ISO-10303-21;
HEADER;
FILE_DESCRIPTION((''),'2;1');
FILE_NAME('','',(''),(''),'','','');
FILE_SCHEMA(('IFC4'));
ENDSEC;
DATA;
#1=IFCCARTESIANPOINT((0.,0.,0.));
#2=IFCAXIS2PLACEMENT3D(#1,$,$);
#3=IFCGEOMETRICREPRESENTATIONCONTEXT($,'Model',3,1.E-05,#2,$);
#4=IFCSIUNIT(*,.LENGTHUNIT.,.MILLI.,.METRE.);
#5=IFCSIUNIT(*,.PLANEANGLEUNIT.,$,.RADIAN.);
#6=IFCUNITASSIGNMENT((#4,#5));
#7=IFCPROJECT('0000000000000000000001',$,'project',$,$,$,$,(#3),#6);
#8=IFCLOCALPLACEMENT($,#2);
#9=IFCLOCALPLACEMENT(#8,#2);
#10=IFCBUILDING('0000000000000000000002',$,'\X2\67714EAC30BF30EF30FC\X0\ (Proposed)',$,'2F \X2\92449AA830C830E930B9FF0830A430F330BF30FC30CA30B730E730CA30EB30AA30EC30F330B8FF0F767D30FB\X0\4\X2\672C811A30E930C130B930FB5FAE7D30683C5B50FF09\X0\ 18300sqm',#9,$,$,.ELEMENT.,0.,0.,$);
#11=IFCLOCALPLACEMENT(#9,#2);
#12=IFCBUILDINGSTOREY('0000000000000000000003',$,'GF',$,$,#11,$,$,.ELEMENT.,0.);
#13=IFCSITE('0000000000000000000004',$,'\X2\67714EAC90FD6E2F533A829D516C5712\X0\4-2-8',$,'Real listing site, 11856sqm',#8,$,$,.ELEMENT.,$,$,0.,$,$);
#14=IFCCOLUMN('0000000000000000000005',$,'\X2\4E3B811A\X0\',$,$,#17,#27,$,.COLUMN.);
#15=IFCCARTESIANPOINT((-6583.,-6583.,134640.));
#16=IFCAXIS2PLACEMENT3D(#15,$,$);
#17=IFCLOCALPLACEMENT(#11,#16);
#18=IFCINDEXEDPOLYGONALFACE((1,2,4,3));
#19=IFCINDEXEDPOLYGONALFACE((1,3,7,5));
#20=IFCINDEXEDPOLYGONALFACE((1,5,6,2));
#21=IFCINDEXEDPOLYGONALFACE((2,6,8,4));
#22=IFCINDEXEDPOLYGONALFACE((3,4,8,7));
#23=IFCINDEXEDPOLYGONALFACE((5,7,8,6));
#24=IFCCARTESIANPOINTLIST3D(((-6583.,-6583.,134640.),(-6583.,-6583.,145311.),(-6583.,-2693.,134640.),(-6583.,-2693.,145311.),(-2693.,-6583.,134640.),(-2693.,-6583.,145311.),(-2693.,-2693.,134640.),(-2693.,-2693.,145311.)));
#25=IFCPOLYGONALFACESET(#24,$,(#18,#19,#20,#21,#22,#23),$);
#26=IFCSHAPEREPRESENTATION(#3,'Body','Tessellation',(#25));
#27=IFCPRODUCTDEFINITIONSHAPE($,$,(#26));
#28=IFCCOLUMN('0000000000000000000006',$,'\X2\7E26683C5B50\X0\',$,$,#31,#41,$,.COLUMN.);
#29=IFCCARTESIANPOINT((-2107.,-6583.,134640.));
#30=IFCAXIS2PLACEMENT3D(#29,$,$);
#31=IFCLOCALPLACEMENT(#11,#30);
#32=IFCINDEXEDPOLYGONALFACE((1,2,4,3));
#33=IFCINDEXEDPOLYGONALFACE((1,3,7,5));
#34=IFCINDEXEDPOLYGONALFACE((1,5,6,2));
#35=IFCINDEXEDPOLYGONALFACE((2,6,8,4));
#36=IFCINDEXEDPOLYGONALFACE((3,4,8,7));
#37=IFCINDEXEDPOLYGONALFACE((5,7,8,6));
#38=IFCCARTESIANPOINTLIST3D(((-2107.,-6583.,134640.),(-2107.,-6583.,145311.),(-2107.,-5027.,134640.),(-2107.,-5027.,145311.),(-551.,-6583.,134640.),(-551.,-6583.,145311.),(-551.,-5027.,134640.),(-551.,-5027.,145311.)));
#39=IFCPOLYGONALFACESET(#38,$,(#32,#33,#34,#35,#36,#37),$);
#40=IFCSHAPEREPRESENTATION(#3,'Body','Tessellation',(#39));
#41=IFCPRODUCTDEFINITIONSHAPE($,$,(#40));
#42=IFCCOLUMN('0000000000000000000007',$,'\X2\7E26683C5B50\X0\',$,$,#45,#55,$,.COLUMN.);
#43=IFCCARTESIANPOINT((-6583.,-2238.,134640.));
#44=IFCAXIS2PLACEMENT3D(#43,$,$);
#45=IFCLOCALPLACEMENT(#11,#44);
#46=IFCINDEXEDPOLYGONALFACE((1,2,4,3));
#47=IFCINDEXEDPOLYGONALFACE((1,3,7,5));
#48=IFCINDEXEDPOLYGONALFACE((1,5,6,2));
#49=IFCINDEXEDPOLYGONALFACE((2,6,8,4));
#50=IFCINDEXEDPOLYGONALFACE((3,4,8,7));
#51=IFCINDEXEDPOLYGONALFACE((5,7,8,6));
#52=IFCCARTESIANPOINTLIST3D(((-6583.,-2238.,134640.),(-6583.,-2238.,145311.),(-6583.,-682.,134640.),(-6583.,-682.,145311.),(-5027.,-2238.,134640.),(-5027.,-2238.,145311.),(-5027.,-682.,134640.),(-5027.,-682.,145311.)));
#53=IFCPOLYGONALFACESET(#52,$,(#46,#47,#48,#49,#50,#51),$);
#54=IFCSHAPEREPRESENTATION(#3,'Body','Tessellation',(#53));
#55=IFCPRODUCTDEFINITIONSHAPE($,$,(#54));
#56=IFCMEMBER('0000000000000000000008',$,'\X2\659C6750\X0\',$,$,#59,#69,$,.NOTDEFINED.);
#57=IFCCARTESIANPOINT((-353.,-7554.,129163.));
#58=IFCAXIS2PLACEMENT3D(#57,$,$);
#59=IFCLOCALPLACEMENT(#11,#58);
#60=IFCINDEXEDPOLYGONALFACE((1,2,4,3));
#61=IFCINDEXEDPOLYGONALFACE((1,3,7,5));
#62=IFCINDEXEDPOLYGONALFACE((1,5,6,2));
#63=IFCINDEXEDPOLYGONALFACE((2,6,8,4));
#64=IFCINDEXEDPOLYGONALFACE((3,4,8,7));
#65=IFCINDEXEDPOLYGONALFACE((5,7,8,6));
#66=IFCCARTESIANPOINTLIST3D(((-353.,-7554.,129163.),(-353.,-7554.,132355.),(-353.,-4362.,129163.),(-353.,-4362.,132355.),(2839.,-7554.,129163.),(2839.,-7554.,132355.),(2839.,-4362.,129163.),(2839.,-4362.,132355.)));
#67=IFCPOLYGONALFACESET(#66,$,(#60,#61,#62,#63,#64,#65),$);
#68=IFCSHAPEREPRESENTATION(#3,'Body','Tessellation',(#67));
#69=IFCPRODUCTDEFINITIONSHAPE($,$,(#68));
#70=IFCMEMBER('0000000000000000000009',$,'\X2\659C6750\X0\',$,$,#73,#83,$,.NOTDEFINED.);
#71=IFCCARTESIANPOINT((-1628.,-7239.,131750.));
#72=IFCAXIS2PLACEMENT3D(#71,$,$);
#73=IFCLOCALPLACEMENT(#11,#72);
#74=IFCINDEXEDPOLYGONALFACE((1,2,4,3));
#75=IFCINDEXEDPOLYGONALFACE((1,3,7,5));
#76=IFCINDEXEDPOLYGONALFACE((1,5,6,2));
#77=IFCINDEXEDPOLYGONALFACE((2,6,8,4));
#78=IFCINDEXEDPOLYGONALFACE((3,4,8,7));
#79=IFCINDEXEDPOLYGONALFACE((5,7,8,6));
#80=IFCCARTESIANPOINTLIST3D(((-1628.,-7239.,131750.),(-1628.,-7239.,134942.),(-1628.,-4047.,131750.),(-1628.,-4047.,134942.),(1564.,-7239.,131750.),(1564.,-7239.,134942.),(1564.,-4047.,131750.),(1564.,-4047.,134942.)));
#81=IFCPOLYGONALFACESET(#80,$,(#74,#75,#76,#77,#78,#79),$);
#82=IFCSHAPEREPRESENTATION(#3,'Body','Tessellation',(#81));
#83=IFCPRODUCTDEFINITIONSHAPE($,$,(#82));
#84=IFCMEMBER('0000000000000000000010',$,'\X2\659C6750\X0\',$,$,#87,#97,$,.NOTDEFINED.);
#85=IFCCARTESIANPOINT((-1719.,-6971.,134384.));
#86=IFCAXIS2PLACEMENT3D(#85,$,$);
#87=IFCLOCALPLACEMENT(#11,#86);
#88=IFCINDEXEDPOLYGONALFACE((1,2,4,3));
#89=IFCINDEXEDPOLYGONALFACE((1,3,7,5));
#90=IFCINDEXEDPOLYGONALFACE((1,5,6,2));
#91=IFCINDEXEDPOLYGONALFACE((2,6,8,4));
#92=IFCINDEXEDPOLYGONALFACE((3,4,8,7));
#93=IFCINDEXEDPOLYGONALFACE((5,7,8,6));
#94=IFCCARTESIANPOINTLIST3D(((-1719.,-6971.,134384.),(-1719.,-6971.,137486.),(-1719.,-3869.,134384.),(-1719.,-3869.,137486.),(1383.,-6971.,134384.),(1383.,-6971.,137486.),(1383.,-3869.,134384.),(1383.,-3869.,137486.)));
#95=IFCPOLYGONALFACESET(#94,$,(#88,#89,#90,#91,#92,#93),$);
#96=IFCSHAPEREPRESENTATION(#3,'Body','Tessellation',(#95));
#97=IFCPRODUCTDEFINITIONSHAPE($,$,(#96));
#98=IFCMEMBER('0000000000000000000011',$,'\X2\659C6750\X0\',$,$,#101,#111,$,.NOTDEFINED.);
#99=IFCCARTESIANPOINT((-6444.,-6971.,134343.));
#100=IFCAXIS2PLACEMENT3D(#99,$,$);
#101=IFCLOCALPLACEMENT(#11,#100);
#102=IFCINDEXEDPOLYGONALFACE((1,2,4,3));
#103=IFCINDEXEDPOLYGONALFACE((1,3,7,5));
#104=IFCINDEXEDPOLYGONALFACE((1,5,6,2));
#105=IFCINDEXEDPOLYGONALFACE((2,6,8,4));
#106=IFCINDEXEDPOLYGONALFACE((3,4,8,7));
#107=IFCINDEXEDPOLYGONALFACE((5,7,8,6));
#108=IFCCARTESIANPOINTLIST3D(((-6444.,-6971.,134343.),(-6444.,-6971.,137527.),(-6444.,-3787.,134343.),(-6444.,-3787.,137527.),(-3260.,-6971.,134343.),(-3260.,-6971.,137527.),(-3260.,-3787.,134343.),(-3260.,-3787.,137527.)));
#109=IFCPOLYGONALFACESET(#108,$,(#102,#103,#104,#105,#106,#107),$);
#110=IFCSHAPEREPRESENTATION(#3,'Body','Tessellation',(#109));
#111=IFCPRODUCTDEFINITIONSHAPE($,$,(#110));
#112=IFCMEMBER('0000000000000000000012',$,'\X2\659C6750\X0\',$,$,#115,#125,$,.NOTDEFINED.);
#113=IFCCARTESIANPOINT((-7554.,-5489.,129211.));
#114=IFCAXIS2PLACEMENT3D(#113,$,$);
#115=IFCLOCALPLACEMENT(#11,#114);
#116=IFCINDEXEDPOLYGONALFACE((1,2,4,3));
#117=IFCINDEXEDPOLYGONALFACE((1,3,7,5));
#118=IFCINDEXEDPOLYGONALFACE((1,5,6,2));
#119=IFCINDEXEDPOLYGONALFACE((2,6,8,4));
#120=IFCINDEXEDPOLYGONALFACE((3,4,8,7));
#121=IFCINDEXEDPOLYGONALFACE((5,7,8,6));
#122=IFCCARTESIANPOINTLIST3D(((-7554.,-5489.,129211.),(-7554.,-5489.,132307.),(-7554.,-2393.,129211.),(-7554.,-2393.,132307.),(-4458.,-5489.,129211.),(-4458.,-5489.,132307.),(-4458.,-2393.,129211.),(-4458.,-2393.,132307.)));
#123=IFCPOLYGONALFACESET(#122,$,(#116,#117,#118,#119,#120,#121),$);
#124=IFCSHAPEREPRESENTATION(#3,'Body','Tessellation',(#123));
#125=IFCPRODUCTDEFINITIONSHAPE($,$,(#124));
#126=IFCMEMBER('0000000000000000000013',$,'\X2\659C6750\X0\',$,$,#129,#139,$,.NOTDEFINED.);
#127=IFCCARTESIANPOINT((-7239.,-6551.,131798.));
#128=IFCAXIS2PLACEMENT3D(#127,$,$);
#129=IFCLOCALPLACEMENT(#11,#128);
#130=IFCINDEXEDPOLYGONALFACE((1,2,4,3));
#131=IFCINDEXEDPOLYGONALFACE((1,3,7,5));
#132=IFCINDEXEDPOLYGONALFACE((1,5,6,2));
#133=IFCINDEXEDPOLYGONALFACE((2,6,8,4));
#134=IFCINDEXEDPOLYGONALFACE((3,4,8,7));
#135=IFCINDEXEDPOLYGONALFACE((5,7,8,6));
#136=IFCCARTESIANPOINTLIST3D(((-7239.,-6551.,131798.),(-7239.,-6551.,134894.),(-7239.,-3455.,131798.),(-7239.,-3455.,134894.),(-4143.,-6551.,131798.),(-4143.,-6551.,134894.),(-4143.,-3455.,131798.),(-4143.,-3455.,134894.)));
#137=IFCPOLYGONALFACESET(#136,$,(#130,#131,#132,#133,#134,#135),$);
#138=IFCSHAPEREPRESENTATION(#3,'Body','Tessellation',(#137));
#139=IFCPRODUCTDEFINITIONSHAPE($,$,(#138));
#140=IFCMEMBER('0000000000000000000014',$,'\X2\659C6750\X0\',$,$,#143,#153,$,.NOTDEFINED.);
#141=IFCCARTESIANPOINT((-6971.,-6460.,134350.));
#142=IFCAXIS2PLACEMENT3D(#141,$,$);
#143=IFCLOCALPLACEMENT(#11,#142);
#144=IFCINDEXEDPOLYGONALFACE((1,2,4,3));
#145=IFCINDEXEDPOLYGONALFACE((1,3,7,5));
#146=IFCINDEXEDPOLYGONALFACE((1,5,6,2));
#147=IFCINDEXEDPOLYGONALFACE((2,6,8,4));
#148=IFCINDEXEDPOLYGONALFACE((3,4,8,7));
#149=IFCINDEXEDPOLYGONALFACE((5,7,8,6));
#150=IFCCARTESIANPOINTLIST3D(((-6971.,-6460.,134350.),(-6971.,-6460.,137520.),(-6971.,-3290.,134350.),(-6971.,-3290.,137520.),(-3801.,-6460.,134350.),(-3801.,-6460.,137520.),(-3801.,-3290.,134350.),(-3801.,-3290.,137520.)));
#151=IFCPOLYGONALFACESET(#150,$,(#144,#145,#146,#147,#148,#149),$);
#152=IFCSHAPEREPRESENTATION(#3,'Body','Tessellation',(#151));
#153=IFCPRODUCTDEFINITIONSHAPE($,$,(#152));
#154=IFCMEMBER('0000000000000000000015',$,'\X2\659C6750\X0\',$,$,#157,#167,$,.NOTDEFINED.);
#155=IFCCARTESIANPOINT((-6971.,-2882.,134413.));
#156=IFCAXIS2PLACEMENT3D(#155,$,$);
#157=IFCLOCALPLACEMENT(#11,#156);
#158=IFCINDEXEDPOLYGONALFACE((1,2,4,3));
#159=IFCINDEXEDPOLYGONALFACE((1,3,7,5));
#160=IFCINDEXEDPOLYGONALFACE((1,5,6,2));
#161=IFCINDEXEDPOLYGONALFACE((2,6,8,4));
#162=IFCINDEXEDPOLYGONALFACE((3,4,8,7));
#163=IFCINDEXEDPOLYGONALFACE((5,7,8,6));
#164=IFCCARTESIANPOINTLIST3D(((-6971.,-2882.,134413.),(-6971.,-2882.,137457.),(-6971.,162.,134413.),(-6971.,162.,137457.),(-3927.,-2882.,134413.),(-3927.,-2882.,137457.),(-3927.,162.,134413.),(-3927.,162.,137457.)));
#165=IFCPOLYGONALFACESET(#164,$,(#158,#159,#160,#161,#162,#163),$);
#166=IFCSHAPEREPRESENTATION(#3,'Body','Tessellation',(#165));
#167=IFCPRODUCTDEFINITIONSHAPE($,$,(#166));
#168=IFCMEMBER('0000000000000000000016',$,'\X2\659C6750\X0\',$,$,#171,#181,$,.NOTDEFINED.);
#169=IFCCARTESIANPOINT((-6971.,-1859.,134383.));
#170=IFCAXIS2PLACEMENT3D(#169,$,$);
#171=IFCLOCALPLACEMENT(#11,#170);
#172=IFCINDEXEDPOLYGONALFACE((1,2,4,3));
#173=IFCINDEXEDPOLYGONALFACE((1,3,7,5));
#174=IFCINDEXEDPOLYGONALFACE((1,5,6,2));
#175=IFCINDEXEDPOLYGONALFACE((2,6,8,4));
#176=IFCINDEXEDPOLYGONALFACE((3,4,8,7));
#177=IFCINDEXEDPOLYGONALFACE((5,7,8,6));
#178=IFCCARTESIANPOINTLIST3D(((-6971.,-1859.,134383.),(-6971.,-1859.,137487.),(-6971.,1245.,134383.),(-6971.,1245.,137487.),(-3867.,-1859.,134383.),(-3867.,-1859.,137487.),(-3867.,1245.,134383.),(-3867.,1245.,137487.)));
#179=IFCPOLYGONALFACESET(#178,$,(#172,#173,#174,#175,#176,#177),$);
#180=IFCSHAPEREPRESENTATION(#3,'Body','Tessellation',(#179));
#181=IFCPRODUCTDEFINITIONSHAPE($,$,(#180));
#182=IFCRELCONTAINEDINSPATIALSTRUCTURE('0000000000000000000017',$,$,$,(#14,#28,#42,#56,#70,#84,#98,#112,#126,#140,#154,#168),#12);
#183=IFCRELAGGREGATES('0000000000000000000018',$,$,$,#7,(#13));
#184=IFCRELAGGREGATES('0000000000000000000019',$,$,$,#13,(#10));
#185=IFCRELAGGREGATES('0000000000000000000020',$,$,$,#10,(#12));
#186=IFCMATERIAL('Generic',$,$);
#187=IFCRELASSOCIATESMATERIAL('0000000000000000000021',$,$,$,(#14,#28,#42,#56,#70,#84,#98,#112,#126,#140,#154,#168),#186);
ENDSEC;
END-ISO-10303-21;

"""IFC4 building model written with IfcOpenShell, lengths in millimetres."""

from ifc_helpers import new_model, si_unit, frame, frame_2d, origin, place, context, project, spatial, rectangle, extrude, material, element, save


model = new_model("IFC4")

# Units and contexts
model_context = context("Model", 3, precision=1e-05, world=origin())
ifc_project = project(units=[si_unit("LENGTHUNIT", "METRE", prefix="MILLI"), si_unit("PLANEANGLEUNIT", "RADIAN")], contexts=[model_context])

# Site, building, storey
site_placement = place(None, origin())
site = spatial("IfcSite", under=ifc_project, at=site_placement, Name="東京都港区芝公園4-2-8", ObjectType="Real listing site, 11856sqm", CompositionType="ELEMENT", RefElevation=0.0)
building_placement = place(site_placement, origin())
building = spatial("IfcBuilding", under=site, at=building_placement, Name="東京タワー (Proposed)", ObjectType="2F 鉄骨トラス（インターナショナルオレンジ／白・4本脚ラチス・微細格子） 18300sqm", CompositionType="ELEMENT", ElevationOfRefHeight=0.0, ElevationOfTerrain=0.0)
storey_placement = place(building_placement, origin())
storey = spatial("IfcBuildingStorey", under=building, at=storey_placement, Name="GF", CompositionType="ELEMENT", Elevation=0.0)

# Columns
ifc_material = material(Name="Generic")
column_1_placement = place(storey_placement, frame((-6583.0, -6583.0, 134640.0)))
element("IfcColumn", 1, at=column_1_placement, inside=storey, material=ifc_material, Name="主脚", PredefinedType="COLUMN", context=model_context, shape_type="SweptSolid", body=[
    extrude(rectangle(XDim=3890.0, YDim=3890.0, at=frame_2d((1945.0, 1945.0))), frame((-6583.0, -6583.0, 134640.0)), (0.0, 0.0, 1.0), 10671.0),
])
column_2_placement = place(storey_placement, frame((-2107.0, -6583.0, 134640.0)))
element("IfcColumn", 2, at=column_2_placement, inside=storey, material=ifc_material, Name="縦格子", PredefinedType="COLUMN", context=model_context, shape_type="SweptSolid", body=[
    extrude(rectangle(XDim=1556.0, YDim=1556.0, at=frame_2d((778.0, 778.0))), frame((-2107.0, -6583.0, 134640.0)), (0.0, 0.0, 1.0), 10671.0),
])
column_3_placement = place(storey_placement, frame((-6583.0, -2238.0, 134640.0)))
element("IfcColumn", 3, at=column_3_placement, inside=storey, material=ifc_material, Name="縦格子", PredefinedType="COLUMN", context=model_context, shape_type="SweptSolid", body=[
    extrude(rectangle(XDim=1556.0, YDim=1556.0, at=frame_2d((778.0, 778.0))), frame((-6583.0, -2238.0, 134640.0)), (0.0, 0.0, 1.0), 10671.0),
])

# Members
member_1_placement = place(storey_placement, frame((-353.0, -7554.0, 129163.0)))
element("IfcMember", 4, at=member_1_placement, inside=storey, material=ifc_material, Name="斜材", PredefinedType="NOTDEFINED", context=model_context, shape_type="SweptSolid", body=[
    extrude(rectangle(XDim=3192.0, YDim=3192.0, at=frame_2d((1596.0, 1596.0))), frame((-353.0, -7554.0, 129163.0)), (0.0, 0.0, 1.0), 3192.0),
])
member_2_placement = place(storey_placement, frame((-1628.0, -7239.0, 131750.0)))
element("IfcMember", 5, at=member_2_placement, inside=storey, material=ifc_material, Name="斜材", PredefinedType="NOTDEFINED", context=model_context, shape_type="SweptSolid", body=[
    extrude(rectangle(XDim=3192.0, YDim=3192.0, at=frame_2d((1596.0, 1596.0))), frame((-1628.0, -7239.0, 131750.0)), (0.0, 0.0, 1.0), 3192.0),
])
member_3_placement = place(storey_placement, frame((-1719.0, -6971.0, 134384.0)))
element("IfcMember", 6, at=member_3_placement, inside=storey, material=ifc_material, Name="斜材", PredefinedType="NOTDEFINED", context=model_context, shape_type="SweptSolid", body=[
    extrude(rectangle(XDim=3102.0, YDim=3102.0, at=frame_2d((1551.0, 1551.0))), frame((-1719.0, -6971.0, 134384.0)), (0.0, 0.0, 1.0), 3102.0),
])
member_4_placement = place(storey_placement, frame((-6444.0, -6971.0, 134343.0)))
element("IfcMember", 7, at=member_4_placement, inside=storey, material=ifc_material, Name="斜材", PredefinedType="NOTDEFINED", context=model_context, shape_type="SweptSolid", body=[
    extrude(rectangle(XDim=3184.0, YDim=3184.0, at=frame_2d((1592.0, 1592.0))), frame((-6444.0, -6971.0, 134343.0)), (0.0, 0.0, 1.0), 3184.0),
])
member_5_placement = place(storey_placement, frame((-7554.0, -5489.0, 129211.0)))
element("IfcMember", 8, at=member_5_placement, inside=storey, material=ifc_material, Name="斜材", PredefinedType="NOTDEFINED", context=model_context, shape_type="SweptSolid", body=[
    extrude(rectangle(XDim=3096.0, YDim=3096.0, at=frame_2d((1548.0, 1548.0))), frame((-7554.0, -5489.0, 129211.0)), (0.0, 0.0, 1.0), 3096.0),
])
member_6_placement = place(storey_placement, frame((-7239.0, -6551.0, 131798.0)))
element("IfcMember", 9, at=member_6_placement, inside=storey, material=ifc_material, Name="斜材", PredefinedType="NOTDEFINED", context=model_context, shape_type="SweptSolid", body=[
    extrude(rectangle(XDim=3096.0, YDim=3096.0, at=frame_2d((1548.0, 1548.0))), frame((-7239.0, -6551.0, 131798.0)), (0.0, 0.0, 1.0), 3096.0),
])
member_7_placement = place(storey_placement, frame((-6971.0, -6460.0, 134350.0)))
element("IfcMember", 10, at=member_7_placement, inside=storey, material=ifc_material, Name="斜材", PredefinedType="NOTDEFINED", context=model_context, shape_type="SweptSolid", body=[
    extrude(rectangle(XDim=3170.0, YDim=3170.0, at=frame_2d((1585.0, 1585.0))), frame((-6971.0, -6460.0, 134350.0)), (0.0, 0.0, 1.0), 3170.0),
])
member_8_placement = place(storey_placement, frame((-6971.0, -2882.0, 134413.0)))
element("IfcMember", 11, at=member_8_placement, inside=storey, material=ifc_material, Name="斜材", PredefinedType="NOTDEFINED", context=model_context, shape_type="SweptSolid", body=[
    extrude(rectangle(XDim=3044.0, YDim=3044.0, at=frame_2d((1522.0, 1522.0))), frame((-6971.0, -2882.0, 134413.0)), (0.0, 0.0, 1.0), 3044.0),
])
member_9_placement = place(storey_placement, frame((-6971.0, -1859.0, 134383.0)))
element("IfcMember", 12, at=member_9_placement, inside=storey, material=ifc_material, Name="斜材", PredefinedType="NOTDEFINED", context=model_context, shape_type="SweptSolid", body=[
    extrude(rectangle(XDim=3104.0, YDim=3104.0, at=frame_2d((1552.0, 1552.0))), frame((-6971.0, -1859.0, 134383.0)), (0.0, 0.0, 1.0), 3104.0),
])

save(model, "model.ifc")
